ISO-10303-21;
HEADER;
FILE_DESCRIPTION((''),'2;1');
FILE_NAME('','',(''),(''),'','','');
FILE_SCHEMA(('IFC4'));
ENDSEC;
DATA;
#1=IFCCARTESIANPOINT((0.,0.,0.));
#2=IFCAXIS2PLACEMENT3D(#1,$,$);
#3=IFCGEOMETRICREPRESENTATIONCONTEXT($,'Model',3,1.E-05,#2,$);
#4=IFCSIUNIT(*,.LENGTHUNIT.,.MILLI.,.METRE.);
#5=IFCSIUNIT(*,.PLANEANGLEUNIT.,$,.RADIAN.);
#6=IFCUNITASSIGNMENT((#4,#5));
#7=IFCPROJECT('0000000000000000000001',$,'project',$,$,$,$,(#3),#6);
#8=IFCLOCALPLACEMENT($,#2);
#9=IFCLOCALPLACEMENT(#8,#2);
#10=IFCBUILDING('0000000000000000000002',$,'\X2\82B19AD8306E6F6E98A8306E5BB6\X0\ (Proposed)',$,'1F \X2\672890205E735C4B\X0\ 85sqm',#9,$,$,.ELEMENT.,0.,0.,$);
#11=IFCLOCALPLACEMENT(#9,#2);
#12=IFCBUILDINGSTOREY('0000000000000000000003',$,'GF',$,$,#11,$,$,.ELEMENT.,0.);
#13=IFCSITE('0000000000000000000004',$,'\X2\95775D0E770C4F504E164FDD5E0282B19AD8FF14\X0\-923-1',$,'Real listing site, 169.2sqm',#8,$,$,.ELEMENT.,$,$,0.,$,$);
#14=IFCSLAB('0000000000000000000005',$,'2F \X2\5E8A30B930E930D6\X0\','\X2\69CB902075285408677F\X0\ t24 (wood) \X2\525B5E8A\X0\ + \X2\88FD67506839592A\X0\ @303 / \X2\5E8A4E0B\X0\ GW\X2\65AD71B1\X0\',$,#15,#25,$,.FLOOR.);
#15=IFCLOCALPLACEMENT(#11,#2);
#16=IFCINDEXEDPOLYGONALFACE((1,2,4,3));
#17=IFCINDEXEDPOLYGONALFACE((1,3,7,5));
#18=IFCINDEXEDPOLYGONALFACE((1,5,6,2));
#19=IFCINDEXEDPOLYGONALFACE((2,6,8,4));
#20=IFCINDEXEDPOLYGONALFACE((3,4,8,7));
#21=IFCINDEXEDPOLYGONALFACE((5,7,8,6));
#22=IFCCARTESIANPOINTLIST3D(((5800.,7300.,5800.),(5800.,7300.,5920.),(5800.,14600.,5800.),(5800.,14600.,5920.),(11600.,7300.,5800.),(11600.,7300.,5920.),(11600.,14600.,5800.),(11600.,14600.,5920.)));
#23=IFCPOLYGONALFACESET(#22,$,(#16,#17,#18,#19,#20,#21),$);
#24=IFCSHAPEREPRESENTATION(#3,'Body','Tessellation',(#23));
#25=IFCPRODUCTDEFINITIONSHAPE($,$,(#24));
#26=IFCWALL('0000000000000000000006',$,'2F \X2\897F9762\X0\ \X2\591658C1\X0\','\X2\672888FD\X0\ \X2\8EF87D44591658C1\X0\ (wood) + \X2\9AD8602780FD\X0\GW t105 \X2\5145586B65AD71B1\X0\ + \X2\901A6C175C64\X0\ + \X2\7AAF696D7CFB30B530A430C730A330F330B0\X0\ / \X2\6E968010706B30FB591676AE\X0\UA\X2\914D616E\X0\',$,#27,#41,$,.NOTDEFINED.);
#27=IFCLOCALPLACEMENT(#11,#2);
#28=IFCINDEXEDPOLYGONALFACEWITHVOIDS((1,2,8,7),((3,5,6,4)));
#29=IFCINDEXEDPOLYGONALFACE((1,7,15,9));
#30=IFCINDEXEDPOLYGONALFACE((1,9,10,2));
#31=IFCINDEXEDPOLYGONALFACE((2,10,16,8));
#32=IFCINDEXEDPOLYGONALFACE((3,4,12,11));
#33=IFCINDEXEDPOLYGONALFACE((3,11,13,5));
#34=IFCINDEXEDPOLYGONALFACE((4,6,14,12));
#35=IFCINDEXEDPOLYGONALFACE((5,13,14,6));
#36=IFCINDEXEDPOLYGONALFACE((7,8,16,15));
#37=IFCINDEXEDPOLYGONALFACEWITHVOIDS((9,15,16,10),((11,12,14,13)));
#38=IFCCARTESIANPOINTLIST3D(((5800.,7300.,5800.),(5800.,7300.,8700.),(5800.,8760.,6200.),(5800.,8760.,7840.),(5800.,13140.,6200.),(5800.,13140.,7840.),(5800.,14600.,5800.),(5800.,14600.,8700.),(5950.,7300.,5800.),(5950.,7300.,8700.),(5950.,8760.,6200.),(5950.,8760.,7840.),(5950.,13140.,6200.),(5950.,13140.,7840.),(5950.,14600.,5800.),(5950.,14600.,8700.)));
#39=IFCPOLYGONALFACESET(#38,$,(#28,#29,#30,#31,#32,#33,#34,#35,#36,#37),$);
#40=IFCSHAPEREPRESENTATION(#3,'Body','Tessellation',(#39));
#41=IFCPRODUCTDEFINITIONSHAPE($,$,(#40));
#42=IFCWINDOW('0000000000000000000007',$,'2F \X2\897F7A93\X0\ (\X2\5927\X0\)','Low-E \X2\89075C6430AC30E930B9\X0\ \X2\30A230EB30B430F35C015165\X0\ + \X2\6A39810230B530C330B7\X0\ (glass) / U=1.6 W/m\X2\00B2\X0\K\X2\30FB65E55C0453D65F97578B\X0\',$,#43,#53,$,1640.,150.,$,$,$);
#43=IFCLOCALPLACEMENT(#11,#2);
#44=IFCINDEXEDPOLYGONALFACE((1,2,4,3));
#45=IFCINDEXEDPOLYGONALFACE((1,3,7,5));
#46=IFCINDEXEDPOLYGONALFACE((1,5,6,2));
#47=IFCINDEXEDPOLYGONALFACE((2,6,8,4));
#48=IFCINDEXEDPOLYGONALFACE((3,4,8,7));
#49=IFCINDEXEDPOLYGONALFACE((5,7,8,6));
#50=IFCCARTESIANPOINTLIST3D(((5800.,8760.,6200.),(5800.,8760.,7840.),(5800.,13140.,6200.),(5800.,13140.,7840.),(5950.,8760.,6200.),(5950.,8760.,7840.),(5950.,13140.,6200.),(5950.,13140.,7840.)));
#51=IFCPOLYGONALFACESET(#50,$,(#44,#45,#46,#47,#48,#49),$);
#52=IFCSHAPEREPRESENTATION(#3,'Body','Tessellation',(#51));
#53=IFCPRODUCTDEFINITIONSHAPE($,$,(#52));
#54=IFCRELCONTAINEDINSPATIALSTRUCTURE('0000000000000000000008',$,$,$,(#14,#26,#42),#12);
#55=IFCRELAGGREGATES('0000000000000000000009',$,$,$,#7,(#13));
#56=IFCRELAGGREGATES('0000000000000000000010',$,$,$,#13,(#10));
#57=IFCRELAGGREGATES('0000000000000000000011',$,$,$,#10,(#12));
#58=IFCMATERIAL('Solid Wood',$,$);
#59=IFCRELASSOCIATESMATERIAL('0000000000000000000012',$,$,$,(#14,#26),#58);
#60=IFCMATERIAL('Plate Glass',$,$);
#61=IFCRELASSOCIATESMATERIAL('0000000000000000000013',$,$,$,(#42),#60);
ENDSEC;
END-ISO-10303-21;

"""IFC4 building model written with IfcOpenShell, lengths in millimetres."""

from ifc_helpers import new_model, si_unit, frame, frame_2d, origin, place, context, project, spatial, rectangle, extrude, material, element, fill, save


model = new_model("IFC4")

# Units and contexts
model_context = context("Model", 3, precision=1e-05, world=origin())
ifc_project = project(units=[si_unit("LENGTHUNIT", "METRE", prefix="MILLI"), si_unit("PLANEANGLEUNIT", "RADIAN")], contexts=[model_context])

# Site, building, storey
site_placement = place(None, origin())
site = spatial("IfcSite", under=ifc_project, at=site_placement, Name="長崎県佐世保市花高４-923-1", ObjectType="Real listing site, 169.2sqm", CompositionType="ELEMENT", RefElevation=0.0)
building_placement = place(site_placement, origin())
building = spatial("IfcBuilding", under=site, at=building_placement, Name="花高の潮風の家 (Proposed)", ObjectType="1F 木造平屋 85sqm", CompositionType="ELEMENT", ElevationOfRefHeight=0.0, ElevationOfTerrain=0.0)
storey_placement = place(building_placement, origin())
storey = spatial("IfcBuildingStorey", under=building, at=storey_placement, Name="GF", CompositionType="ELEMENT", Elevation=0.0)

# Slab
ifc_material_1 = material(Name="Solid Wood")
slab_placement = place(storey_placement, frame((2900.0, 3650.0, 2900.0)))
element("IfcSlab", 1, at=slab_placement, inside=storey, material=ifc_material_1, Name="2F 床スラブ", Description="構造用合板 t24 (wood) 剛床 + 製材根太 @303 / 床下 GW断熱", PredefinedType="FLOOR", context=model_context, shape_type="SweptSolid", body=[
    extrude(rectangle(XDim=5800.0, YDim=7300.0, at=frame_2d((2900.0, 3650.0))), frame((2900.0, 3650.0, 2900.0)), (0.0, 0.0, 1.0), 120.0),
])

# Shared definitions
ifc_material_2 = material(Name="Plate Glass")

# Wall, opening, window
wall_1_placement = place(storey_placement, frame((2900.0, 3650.0, 2900.0)))
wall_1 = element("IfcWall", 2, at=wall_1_placement, inside=storey, material=ifc_material_1, Name="2F 西面 外壁", Description="木製 軸組外壁 (wood) + 高性能GW t105 充填断熱 + 通気層 + 窯業系サイディング / 準耐火・外皮UA配慮", PredefinedType="NOTDEFINED", context=model_context, shape_type="SweptSolid", body=[
    extrude(rectangle(XDim=150.0, YDim=7300.0, at=frame_2d((75.0, 3650.0))), frame((2900.0, 3650.0, 2900.0)), (0.0, 0.0, 1.0), 2900.0),
])
opening_1_placement = place(storey_placement, frame((2900.0, 4380.0, 3100.0)))
opening_1 = element("IfcOpeningElement", 3, at=opening_1_placement, cuts=wall_1, PredefinedType="NOTDEFINED", context=model_context, shape_type="SweptSolid", body=[
    extrude(rectangle(XDim=150.0, YDim=4380.0, at=frame_2d((75.0, 2190.0))), frame((2900.0, 4380.0, 3100.0)), (0.0, 0.0, 1.0), 1640.0),
])
window_1_placement = place(storey_placement, frame((2900.0, 4380.0, 3100.0)))
window_1 = element("IfcWindow", 4, at=window_1_placement, inside=storey, material=ifc_material_2, Name="2F 西窓 (大)", Description="Low-E 複層ガラス アルゴン封入 + 樹脂サッシ (glass) / U=1.6 W/m²K・日射取得型", OverallHeight=1640.0, OverallWidth=150.0, context=model_context, shape_type="SweptSolid", body=[
    extrude(rectangle(XDim=150.0, YDim=4380.0, at=frame_2d((75.0, 2190.0))), frame((2900.0, 4380.0, 3100.0)), (0.0, 0.0, 1.0), 1640.0),
])
fill(opening_1, window_1)

save(model, "model.ifc")
